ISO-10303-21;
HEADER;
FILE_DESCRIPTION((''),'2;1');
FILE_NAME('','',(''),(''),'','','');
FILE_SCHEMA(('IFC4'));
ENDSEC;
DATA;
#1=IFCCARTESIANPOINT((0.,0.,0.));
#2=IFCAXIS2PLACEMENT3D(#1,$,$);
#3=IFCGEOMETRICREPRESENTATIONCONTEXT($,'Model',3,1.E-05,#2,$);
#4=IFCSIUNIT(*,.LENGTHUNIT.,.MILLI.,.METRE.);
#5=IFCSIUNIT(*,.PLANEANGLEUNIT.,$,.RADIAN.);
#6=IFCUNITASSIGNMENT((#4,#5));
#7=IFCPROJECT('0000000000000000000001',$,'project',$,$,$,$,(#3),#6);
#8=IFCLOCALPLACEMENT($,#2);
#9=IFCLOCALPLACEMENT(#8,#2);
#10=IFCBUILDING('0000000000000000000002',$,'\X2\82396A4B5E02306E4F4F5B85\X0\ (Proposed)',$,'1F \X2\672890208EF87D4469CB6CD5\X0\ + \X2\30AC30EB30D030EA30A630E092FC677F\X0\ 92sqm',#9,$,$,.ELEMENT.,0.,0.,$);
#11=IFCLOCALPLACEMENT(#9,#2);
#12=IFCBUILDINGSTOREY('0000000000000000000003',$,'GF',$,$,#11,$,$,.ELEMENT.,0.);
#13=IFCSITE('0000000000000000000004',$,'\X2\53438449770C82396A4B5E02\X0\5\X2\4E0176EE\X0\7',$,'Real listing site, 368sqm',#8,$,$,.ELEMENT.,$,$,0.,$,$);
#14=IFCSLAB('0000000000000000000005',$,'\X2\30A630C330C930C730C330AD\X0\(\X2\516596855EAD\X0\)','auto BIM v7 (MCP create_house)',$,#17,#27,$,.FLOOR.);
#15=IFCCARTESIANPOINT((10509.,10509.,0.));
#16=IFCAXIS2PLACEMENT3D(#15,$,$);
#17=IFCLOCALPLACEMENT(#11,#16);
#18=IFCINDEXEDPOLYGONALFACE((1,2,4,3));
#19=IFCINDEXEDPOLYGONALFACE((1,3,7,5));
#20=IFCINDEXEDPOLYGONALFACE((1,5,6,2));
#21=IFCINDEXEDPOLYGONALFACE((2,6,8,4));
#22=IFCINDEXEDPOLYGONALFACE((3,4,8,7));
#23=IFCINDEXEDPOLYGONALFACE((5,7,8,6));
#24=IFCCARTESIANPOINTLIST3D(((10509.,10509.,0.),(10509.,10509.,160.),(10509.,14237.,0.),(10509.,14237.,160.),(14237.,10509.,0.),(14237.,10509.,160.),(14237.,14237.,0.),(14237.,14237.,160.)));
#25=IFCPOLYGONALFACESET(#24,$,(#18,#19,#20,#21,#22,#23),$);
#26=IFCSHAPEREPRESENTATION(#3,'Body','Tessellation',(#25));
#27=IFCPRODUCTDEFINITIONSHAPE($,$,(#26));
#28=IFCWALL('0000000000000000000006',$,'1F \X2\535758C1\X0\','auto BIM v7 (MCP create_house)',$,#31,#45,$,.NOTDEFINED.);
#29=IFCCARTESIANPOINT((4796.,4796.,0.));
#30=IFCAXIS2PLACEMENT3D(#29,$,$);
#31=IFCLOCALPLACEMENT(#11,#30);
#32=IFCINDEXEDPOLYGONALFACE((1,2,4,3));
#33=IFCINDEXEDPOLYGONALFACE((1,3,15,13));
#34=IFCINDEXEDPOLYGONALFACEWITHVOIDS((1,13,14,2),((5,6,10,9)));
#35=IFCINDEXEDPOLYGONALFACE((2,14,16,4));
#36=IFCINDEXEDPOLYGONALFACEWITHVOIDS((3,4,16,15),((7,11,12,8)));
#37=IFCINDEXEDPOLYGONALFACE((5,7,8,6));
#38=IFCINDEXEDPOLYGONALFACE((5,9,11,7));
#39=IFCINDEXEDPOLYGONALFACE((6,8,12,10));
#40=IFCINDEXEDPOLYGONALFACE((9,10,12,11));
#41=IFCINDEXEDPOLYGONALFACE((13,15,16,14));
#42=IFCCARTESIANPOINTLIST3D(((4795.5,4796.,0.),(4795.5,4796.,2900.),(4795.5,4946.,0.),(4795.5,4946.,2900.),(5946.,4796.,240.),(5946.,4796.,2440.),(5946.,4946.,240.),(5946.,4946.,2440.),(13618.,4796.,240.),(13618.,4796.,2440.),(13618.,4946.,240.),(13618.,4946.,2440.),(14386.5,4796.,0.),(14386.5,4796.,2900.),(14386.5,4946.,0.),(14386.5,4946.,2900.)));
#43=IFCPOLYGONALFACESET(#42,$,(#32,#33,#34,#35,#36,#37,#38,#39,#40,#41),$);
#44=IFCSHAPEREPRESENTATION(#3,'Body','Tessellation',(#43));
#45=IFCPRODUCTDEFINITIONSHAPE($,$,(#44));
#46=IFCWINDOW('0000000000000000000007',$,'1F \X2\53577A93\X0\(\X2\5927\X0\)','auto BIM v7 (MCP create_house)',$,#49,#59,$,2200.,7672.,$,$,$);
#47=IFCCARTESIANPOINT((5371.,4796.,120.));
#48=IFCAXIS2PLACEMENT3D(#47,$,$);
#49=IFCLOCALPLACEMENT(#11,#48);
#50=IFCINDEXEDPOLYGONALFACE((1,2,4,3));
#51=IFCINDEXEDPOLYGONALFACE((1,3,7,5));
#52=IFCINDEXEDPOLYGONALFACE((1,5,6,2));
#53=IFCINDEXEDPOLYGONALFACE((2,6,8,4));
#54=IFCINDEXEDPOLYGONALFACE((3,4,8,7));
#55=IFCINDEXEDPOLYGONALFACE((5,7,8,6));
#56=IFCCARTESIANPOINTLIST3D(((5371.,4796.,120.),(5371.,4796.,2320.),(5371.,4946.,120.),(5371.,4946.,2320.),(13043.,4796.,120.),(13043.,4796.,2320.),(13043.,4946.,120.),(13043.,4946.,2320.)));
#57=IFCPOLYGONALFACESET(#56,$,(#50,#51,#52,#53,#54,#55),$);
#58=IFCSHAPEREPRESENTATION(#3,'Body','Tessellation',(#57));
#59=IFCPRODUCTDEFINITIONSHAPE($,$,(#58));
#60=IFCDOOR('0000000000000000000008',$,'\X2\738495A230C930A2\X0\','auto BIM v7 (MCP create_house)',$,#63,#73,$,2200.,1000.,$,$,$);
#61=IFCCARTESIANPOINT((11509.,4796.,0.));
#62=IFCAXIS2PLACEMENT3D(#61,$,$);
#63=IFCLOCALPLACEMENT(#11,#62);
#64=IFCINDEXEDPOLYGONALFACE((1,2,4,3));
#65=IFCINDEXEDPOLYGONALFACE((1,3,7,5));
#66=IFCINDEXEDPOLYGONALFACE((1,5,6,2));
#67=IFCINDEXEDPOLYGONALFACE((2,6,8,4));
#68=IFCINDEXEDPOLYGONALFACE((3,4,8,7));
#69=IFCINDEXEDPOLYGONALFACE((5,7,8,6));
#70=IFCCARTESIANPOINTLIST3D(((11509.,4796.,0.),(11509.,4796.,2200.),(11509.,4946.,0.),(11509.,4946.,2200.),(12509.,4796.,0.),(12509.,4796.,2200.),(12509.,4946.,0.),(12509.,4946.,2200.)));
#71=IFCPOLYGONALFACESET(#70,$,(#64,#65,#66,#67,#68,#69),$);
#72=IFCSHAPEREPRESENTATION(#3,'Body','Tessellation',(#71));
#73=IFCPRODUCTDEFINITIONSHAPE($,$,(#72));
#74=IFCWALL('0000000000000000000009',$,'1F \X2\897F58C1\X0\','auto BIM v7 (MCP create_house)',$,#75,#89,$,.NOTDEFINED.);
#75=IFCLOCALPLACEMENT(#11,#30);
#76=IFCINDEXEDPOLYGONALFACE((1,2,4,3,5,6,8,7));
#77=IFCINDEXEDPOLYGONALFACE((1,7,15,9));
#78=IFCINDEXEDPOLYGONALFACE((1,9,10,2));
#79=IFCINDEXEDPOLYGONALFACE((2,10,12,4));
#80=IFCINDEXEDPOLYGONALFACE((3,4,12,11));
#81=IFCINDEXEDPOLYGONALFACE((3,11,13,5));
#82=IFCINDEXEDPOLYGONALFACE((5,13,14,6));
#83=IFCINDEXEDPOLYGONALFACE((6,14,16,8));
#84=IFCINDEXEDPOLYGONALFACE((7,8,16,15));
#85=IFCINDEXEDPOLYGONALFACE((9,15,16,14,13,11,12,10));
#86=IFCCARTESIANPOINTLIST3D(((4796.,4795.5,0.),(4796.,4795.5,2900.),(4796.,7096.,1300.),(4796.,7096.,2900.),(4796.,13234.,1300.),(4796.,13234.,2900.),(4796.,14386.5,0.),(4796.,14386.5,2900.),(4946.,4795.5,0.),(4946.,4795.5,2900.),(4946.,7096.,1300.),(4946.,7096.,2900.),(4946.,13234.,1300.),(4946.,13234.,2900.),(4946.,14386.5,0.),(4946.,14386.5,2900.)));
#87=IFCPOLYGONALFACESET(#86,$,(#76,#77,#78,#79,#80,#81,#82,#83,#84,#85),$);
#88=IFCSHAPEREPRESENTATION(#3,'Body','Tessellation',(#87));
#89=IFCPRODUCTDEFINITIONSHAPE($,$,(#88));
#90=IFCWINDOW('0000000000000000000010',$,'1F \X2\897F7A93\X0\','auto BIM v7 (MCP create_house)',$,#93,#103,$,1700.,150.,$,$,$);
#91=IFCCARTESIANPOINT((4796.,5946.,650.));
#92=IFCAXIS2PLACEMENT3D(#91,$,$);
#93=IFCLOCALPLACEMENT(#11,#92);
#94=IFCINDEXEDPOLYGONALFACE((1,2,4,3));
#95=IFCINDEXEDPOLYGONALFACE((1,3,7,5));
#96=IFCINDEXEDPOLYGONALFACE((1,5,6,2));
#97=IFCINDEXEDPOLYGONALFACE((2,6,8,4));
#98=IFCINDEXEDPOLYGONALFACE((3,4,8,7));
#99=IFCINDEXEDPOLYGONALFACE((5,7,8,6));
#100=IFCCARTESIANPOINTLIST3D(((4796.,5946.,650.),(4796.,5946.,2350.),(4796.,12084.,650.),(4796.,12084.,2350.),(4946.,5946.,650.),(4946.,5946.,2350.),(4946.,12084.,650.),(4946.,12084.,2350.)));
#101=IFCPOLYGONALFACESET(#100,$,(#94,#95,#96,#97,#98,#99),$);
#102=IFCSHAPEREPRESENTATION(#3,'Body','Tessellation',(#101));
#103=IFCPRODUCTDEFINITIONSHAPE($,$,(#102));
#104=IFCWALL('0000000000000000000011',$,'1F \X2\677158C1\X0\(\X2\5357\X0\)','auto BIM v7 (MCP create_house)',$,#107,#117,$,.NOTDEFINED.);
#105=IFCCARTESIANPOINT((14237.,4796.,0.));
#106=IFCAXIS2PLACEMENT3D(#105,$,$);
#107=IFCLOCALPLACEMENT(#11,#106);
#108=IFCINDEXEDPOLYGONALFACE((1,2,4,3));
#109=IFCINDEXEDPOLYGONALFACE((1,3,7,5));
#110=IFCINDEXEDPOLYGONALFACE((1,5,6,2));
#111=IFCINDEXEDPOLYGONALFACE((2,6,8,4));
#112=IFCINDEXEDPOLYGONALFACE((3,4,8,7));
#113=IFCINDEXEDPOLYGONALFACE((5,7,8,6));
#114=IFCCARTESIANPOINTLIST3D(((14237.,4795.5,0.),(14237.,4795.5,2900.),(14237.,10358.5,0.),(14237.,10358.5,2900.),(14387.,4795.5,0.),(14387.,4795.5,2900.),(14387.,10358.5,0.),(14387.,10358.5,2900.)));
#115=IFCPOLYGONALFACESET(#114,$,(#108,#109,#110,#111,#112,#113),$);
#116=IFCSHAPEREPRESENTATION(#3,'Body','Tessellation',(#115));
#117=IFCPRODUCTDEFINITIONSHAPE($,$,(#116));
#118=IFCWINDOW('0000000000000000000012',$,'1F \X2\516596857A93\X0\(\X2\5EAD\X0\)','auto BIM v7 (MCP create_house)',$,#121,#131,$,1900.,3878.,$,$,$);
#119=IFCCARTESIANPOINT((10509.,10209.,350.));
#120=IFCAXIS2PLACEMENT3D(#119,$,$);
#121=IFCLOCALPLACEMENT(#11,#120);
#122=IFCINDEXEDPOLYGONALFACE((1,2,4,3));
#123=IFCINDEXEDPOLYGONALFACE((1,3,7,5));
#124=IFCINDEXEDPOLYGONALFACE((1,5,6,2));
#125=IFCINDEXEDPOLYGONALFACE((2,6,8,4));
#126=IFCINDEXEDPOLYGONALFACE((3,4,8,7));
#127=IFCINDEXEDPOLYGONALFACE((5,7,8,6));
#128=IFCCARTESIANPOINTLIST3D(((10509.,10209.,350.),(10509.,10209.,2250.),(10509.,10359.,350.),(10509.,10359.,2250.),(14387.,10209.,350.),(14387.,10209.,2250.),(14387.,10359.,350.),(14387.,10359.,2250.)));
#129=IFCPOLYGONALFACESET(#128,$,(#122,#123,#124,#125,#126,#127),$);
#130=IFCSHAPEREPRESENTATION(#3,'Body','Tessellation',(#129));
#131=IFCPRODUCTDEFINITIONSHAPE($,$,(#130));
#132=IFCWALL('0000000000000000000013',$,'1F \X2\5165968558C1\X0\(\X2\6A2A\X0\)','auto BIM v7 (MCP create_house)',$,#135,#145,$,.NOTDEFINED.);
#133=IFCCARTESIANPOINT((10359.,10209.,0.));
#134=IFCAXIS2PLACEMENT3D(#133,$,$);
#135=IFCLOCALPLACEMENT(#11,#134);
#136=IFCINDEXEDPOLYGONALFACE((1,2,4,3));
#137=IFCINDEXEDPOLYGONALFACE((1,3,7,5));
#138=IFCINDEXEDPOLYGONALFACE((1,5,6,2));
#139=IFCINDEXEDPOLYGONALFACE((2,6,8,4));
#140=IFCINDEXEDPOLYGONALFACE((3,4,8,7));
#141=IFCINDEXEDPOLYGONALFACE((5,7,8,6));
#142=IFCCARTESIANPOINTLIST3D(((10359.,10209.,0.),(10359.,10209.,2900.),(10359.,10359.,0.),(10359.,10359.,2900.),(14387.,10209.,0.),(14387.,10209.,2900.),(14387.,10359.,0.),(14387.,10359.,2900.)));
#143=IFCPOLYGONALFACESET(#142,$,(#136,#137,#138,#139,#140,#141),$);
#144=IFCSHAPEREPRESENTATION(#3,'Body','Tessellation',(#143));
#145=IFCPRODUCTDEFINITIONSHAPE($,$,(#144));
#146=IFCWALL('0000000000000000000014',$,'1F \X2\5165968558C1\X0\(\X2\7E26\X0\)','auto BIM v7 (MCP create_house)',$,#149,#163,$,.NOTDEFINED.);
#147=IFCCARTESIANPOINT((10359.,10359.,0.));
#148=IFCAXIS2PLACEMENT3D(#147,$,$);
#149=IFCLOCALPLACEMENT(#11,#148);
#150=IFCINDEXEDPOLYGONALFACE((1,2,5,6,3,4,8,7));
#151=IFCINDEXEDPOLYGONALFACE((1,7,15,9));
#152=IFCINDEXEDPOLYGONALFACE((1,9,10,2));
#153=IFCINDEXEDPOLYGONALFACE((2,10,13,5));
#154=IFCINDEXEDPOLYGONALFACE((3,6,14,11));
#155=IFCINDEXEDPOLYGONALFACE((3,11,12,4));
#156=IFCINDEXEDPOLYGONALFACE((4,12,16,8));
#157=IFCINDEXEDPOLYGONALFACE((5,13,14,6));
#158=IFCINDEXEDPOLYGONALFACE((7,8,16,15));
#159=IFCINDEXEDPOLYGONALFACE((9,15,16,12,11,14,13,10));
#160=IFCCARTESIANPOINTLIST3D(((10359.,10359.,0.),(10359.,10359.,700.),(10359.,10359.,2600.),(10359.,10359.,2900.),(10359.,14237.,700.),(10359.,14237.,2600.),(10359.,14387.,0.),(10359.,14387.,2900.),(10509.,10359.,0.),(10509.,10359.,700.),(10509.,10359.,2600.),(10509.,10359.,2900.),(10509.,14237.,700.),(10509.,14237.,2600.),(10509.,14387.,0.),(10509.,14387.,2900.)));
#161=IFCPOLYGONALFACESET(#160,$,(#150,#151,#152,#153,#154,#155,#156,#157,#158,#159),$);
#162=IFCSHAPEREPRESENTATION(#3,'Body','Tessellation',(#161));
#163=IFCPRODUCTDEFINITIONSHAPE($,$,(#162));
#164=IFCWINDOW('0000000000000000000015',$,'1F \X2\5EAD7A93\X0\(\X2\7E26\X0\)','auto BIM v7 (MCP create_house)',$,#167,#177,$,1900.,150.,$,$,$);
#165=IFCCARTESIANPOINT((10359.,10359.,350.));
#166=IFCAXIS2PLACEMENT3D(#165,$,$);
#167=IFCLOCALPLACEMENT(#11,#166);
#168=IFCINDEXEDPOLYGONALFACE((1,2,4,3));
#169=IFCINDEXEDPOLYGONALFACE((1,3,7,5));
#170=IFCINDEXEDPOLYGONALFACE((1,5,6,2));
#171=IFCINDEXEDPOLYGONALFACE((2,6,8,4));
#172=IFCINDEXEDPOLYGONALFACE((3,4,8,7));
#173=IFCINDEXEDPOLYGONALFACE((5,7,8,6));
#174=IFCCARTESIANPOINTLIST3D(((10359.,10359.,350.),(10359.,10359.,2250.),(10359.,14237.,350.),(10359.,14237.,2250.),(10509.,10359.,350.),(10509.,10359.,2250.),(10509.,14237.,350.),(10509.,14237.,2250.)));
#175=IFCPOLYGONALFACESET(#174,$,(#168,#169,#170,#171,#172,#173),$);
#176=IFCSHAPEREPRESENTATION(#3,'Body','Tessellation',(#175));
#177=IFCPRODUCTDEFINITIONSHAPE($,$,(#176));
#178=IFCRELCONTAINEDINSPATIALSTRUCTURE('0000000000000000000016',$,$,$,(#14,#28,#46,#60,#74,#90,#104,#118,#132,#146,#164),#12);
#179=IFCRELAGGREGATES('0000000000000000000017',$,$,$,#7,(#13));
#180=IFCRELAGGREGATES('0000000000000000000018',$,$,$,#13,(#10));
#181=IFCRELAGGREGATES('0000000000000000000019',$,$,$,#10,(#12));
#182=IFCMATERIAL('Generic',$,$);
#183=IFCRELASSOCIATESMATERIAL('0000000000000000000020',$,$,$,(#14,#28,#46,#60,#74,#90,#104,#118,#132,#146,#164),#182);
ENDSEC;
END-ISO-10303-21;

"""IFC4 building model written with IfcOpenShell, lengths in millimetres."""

from ifc_helpers import new_model, si_unit, frame, frame_2d, origin, place, context, project, spatial, rectangle, extrude, material, element, fill, save


model = new_model("IFC4")

# Units and contexts
model_context = context("Model", 3, precision=1e-05, world=origin())
ifc_project = project(units=[si_unit("LENGTHUNIT", "METRE", prefix="MILLI"), si_unit("PLANEANGLEUNIT", "RADIAN")], contexts=[model_context])

# Site, building, storey
site_placement = place(None, origin())
site = spatial("IfcSite", under=ifc_project, at=site_placement, Name="千葉県船橋市5丁目7", ObjectType="Real listing site, 368sqm", CompositionType="ELEMENT", RefElevation=0.0)
building_placement = place(site_placement, origin())
building = spatial("IfcBuilding", under=site, at=building_placement, Name="船橋市の住宅 (Proposed)", ObjectType="1F 木造軸組構法 + ガルバリウム鋼板 92sqm", CompositionType="ELEMENT", ElevationOfRefHeight=0.0, ElevationOfTerrain=0.0)
storey_placement = place(building_placement, origin())
storey = spatial("IfcBuildingStorey", under=building, at=storey_placement, Name="GF", CompositionType="ELEMENT", Elevation=0.0)

# Slab
ifc_material = material(Name="Generic")
slab_1_placement = place(storey_placement, frame((10509.0, 10509.0, 0.0)))
element("IfcSlab", 1, at=slab_1_placement, inside=storey, material=ifc_material, Name="ウッドデッキ(入隅庭)", Description="auto BIM v7 (MCP create_house)", PredefinedType="FLOOR", context=model_context, shape_type="SweptSolid", body=[
    extrude(rectangle(XDim=3728.0, YDim=3728.0, at=frame_2d((1864.0, 1864.0))), frame((10509.0, 10509.0, 0.0)), (0.0, 0.0, 1.0), 160.0),
])

# Wall, openings, window, door
wall_1_placement = place(storey_placement, frame((4796.0, 4796.0, 0.0)))
wall_1 = element("IfcWall", 2, at=wall_1_placement, inside=storey, material=ifc_material, Name="1F 南壁", Description="auto BIM v7 (MCP create_house)", PredefinedType="NOTDEFINED", context=model_context, shape_type="SweptSolid", body=[
    extrude(rectangle(XDim=9591.0, YDim=150.0, at=frame_2d((4795.0, 75.0))), frame((4796.0, 4796.0, 0.0)), (0.0, 0.0, 1.0), 2900.0),
])
opening_1_placement = place(storey_placement, frame((5371.0, 4796.0, 120.0)))
opening_1 = element("IfcOpeningElement", 3, at=opening_1_placement, cuts=wall_1, PredefinedType="NOTDEFINED", context=model_context, shape_type="SweptSolid", body=[
    extrude(rectangle(XDim=7672.0, YDim=150.0, at=frame_2d((3836.0, 75.0))), frame((5371.0, 4796.0, 120.0)), (0.0, 0.0, 1.0), 2200.0),
])
opening_2_placement = place(storey_placement, frame((11509.0, 4796.0, 0.0)))
opening_2 = element("IfcOpeningElement", 4, at=opening_2_placement, cuts=wall_1, PredefinedType="NOTDEFINED", context=model_context, shape_type="SweptSolid", body=[
    extrude(rectangle(XDim=1000.0, YDim=150.0, at=frame_2d((500.0, 75.0))), frame((11509.0, 4796.0, 0.0)), (0.0, 0.0, 1.0), 2200.0),
])
window_1_placement = place(storey_placement, frame((5371.0, 4796.0, 120.0)))
window_1 = element("IfcWindow", 5, at=window_1_placement, inside=storey, material=ifc_material, Name="1F 南窓(大)", Description="auto BIM v7 (MCP create_house)", OverallHeight=2200.0, OverallWidth=7672.0, context=model_context, shape_type="SweptSolid", body=[
    extrude(rectangle(XDim=7672.0, YDim=150.0, at=frame_2d((3836.0, 75.0))), frame((5371.0, 4796.0, 120.0)), (0.0, 0.0, 1.0), 2200.0),
])
fill(opening_1, window_1)
door_placement = place(storey_placement, frame((11509.0, 4796.0, 0.0)))
door = element("IfcDoor", 6, at=door_placement, inside=storey, material=ifc_material, Name="玄関ドア", Description="auto BIM v7 (MCP create_house)", OverallHeight=2200.0, OverallWidth=1000.0, context=model_context, shape_type="SweptSolid", body=[
    extrude(rectangle(XDim=1000.0, YDim=150.0, at=frame_2d((500.0, 75.0))), frame((11509.0, 4796.0, 0.0)), (0.0, 0.0, 1.0), 2200.0),
])
fill(opening_2, door)

# Wall, opening, window
wall_2_placement = place(storey_placement, frame((4796.0, 4796.0, 0.0)))
wall_2 = element("IfcWall", 7, at=wall_2_placement, inside=storey, material=ifc_material, Name="1F 西壁", Description="auto BIM v7 (MCP create_house)", PredefinedType="NOTDEFINED", context=model_context, shape_type="SweptSolid", body=[
    extrude(rectangle(XDim=150.0, YDim=9591.0, at=frame_2d((75.0, 4795.0))), frame((4796.0, 4796.0, 0.0)), (0.0, 0.0, 1.0), 2900.0),
])
opening_3_placement = place(storey_placement, frame((4796.0, 5946.0, 650.0)))
opening_3 = element("IfcOpeningElement", 8, at=opening_3_placement, cuts=wall_2, PredefinedType="NOTDEFINED", context=model_context, shape_type="SweptSolid", body=[
    extrude(rectangle(XDim=150.0, YDim=6138.0, at=frame_2d((75.0, 3069.0))), frame((4796.0, 5946.0, 650.0)), (0.0, 0.0, 1.0), 1700.0),
])
window_2_placement = place(storey_placement, frame((4796.0, 5946.0, 650.0)))
window_2 = element("IfcWindow", 9, at=window_2_placement, inside=storey, material=ifc_material, Name="1F 西窓", Description="auto BIM v7 (MCP create_house)", OverallHeight=1700.0, OverallWidth=150.0, context=model_context, shape_type="SweptSolid", body=[
    extrude(rectangle(XDim=150.0, YDim=6138.0, at=frame_2d((75.0, 3069.0))), frame((4796.0, 5946.0, 650.0)), (0.0, 0.0, 1.0), 1700.0),
])
fill(opening_3, window_2)

# Wall, opening, window
wall_3_placement = place(storey_placement, frame((14237.0, 4796.0, 0.0)))
wall_3 = element("IfcWall", 10, at=wall_3_placement, inside=storey, material=ifc_material, Name="1F 東壁(南)", Description="auto BIM v7 (MCP create_house)", PredefinedType="NOTDEFINED", context=model_context, shape_type="SweptSolid", body=[
    extrude(rectangle(XDim=150.0, YDim=5563.0, at=frame_2d((75.0, 2781.0))), frame((14237.0, 4796.0, 0.0)), (0.0, 0.0, 1.0), 2900.0),
])
opening_4_placement = place(storey_placement, frame((10509.0, 10209.0, 350.0)))
opening_4 = element("IfcOpeningElement", 11, at=opening_4_placement, cuts=wall_3, PredefinedType="NOTDEFINED", context=model_context, shape_type="SweptSolid", body=[
    extrude(rectangle(XDim=3878.0, YDim=150.0, at=frame_2d((1939.0, 75.0))), frame((10509.0, 10209.0, 350.0)), (0.0, 0.0, 1.0), 1900.0),
])
window_3_placement = place(storey_placement, frame((10509.0, 10209.0, 350.0)))
window_3 = element("IfcWindow", 12, at=window_3_placement, inside=storey, material=ifc_material, Name="1F 入隅窓(庭)", Description="auto BIM v7 (MCP create_house)", OverallHeight=1900.0, OverallWidth=3878.0, context=model_context, shape_type="SweptSolid", body=[
    extrude(rectangle(XDim=3878.0, YDim=150.0, at=frame_2d((1939.0, 75.0))), frame((10509.0, 10209.0, 350.0)), (0.0, 0.0, 1.0), 1900.0),
])
fill(opening_4, window_3)

# Wall
wall_4_placement = place(storey_placement, frame((10359.0, 10209.0, 0.0)))
element("IfcWall", 13, at=wall_4_placement, inside=storey, material=ifc_material, Name="1F 入隅壁(横)", Description="auto BIM v7 (MCP create_house)", PredefinedType="NOTDEFINED", context=model_context, shape_type="SweptSolid", body=[
    extrude(rectangle(XDim=4028.0, YDim=150.0, at=frame_2d((2014.0, 75.0))), frame((10359.0, 10209.0, 0.0)), (0.0, 0.0, 1.0), 2900.0),
])

# Wall, opening, window
wall_5_placement = place(storey_placement, frame((10359.0, 10359.0, 0.0)))
wall_5 = element("IfcWall", 14, at=wall_5_placement, inside=storey, material=ifc_material, Name="1F 入隅壁(縦)", Description="auto BIM v7 (MCP create_house)", PredefinedType="NOTDEFINED", context=model_context, shape_type="SweptSolid", body=[
    extrude(rectangle(XDim=150.0, YDim=4028.0, at=frame_2d((75.0, 2014.0))), frame((10359.0, 10359.0, 0.0)), (0.0, 0.0, 1.0), 2900.0),
])
opening_5_placement = place(storey_placement, frame((10359.0, 10359.0, 350.0)))
opening_5 = element("IfcOpeningElement", 15, at=opening_5_placement, cuts=wall_5, PredefinedType="NOTDEFINED", context=model_context, shape_type="SweptSolid", body=[
    extrude(rectangle(XDim=150.0, YDim=3878.0, at=frame_2d((75.0, 1939.0))), frame((10359.0, 10359.0, 350.0)), (0.0, 0.0, 1.0), 1900.0),
])
window_4_placement = place(storey_placement, frame((10359.0, 10359.0, 350.0)))
window_4 = element("IfcWindow", 16, at=window_4_placement, inside=storey, material=ifc_material, Name="1F 庭窓(縦)", Description="auto BIM v7 (MCP create_house)", OverallHeight=1900.0, OverallWidth=150.0, context=model_context, shape_type="SweptSolid", body=[
    extrude(rectangle(XDim=150.0, YDim=3878.0, at=frame_2d((75.0, 1939.0))), frame((10359.0, 10359.0, 350.0)), (0.0, 0.0, 1.0), 1900.0),
])
fill(opening_5, window_4)

save(model, "model.ifc")
